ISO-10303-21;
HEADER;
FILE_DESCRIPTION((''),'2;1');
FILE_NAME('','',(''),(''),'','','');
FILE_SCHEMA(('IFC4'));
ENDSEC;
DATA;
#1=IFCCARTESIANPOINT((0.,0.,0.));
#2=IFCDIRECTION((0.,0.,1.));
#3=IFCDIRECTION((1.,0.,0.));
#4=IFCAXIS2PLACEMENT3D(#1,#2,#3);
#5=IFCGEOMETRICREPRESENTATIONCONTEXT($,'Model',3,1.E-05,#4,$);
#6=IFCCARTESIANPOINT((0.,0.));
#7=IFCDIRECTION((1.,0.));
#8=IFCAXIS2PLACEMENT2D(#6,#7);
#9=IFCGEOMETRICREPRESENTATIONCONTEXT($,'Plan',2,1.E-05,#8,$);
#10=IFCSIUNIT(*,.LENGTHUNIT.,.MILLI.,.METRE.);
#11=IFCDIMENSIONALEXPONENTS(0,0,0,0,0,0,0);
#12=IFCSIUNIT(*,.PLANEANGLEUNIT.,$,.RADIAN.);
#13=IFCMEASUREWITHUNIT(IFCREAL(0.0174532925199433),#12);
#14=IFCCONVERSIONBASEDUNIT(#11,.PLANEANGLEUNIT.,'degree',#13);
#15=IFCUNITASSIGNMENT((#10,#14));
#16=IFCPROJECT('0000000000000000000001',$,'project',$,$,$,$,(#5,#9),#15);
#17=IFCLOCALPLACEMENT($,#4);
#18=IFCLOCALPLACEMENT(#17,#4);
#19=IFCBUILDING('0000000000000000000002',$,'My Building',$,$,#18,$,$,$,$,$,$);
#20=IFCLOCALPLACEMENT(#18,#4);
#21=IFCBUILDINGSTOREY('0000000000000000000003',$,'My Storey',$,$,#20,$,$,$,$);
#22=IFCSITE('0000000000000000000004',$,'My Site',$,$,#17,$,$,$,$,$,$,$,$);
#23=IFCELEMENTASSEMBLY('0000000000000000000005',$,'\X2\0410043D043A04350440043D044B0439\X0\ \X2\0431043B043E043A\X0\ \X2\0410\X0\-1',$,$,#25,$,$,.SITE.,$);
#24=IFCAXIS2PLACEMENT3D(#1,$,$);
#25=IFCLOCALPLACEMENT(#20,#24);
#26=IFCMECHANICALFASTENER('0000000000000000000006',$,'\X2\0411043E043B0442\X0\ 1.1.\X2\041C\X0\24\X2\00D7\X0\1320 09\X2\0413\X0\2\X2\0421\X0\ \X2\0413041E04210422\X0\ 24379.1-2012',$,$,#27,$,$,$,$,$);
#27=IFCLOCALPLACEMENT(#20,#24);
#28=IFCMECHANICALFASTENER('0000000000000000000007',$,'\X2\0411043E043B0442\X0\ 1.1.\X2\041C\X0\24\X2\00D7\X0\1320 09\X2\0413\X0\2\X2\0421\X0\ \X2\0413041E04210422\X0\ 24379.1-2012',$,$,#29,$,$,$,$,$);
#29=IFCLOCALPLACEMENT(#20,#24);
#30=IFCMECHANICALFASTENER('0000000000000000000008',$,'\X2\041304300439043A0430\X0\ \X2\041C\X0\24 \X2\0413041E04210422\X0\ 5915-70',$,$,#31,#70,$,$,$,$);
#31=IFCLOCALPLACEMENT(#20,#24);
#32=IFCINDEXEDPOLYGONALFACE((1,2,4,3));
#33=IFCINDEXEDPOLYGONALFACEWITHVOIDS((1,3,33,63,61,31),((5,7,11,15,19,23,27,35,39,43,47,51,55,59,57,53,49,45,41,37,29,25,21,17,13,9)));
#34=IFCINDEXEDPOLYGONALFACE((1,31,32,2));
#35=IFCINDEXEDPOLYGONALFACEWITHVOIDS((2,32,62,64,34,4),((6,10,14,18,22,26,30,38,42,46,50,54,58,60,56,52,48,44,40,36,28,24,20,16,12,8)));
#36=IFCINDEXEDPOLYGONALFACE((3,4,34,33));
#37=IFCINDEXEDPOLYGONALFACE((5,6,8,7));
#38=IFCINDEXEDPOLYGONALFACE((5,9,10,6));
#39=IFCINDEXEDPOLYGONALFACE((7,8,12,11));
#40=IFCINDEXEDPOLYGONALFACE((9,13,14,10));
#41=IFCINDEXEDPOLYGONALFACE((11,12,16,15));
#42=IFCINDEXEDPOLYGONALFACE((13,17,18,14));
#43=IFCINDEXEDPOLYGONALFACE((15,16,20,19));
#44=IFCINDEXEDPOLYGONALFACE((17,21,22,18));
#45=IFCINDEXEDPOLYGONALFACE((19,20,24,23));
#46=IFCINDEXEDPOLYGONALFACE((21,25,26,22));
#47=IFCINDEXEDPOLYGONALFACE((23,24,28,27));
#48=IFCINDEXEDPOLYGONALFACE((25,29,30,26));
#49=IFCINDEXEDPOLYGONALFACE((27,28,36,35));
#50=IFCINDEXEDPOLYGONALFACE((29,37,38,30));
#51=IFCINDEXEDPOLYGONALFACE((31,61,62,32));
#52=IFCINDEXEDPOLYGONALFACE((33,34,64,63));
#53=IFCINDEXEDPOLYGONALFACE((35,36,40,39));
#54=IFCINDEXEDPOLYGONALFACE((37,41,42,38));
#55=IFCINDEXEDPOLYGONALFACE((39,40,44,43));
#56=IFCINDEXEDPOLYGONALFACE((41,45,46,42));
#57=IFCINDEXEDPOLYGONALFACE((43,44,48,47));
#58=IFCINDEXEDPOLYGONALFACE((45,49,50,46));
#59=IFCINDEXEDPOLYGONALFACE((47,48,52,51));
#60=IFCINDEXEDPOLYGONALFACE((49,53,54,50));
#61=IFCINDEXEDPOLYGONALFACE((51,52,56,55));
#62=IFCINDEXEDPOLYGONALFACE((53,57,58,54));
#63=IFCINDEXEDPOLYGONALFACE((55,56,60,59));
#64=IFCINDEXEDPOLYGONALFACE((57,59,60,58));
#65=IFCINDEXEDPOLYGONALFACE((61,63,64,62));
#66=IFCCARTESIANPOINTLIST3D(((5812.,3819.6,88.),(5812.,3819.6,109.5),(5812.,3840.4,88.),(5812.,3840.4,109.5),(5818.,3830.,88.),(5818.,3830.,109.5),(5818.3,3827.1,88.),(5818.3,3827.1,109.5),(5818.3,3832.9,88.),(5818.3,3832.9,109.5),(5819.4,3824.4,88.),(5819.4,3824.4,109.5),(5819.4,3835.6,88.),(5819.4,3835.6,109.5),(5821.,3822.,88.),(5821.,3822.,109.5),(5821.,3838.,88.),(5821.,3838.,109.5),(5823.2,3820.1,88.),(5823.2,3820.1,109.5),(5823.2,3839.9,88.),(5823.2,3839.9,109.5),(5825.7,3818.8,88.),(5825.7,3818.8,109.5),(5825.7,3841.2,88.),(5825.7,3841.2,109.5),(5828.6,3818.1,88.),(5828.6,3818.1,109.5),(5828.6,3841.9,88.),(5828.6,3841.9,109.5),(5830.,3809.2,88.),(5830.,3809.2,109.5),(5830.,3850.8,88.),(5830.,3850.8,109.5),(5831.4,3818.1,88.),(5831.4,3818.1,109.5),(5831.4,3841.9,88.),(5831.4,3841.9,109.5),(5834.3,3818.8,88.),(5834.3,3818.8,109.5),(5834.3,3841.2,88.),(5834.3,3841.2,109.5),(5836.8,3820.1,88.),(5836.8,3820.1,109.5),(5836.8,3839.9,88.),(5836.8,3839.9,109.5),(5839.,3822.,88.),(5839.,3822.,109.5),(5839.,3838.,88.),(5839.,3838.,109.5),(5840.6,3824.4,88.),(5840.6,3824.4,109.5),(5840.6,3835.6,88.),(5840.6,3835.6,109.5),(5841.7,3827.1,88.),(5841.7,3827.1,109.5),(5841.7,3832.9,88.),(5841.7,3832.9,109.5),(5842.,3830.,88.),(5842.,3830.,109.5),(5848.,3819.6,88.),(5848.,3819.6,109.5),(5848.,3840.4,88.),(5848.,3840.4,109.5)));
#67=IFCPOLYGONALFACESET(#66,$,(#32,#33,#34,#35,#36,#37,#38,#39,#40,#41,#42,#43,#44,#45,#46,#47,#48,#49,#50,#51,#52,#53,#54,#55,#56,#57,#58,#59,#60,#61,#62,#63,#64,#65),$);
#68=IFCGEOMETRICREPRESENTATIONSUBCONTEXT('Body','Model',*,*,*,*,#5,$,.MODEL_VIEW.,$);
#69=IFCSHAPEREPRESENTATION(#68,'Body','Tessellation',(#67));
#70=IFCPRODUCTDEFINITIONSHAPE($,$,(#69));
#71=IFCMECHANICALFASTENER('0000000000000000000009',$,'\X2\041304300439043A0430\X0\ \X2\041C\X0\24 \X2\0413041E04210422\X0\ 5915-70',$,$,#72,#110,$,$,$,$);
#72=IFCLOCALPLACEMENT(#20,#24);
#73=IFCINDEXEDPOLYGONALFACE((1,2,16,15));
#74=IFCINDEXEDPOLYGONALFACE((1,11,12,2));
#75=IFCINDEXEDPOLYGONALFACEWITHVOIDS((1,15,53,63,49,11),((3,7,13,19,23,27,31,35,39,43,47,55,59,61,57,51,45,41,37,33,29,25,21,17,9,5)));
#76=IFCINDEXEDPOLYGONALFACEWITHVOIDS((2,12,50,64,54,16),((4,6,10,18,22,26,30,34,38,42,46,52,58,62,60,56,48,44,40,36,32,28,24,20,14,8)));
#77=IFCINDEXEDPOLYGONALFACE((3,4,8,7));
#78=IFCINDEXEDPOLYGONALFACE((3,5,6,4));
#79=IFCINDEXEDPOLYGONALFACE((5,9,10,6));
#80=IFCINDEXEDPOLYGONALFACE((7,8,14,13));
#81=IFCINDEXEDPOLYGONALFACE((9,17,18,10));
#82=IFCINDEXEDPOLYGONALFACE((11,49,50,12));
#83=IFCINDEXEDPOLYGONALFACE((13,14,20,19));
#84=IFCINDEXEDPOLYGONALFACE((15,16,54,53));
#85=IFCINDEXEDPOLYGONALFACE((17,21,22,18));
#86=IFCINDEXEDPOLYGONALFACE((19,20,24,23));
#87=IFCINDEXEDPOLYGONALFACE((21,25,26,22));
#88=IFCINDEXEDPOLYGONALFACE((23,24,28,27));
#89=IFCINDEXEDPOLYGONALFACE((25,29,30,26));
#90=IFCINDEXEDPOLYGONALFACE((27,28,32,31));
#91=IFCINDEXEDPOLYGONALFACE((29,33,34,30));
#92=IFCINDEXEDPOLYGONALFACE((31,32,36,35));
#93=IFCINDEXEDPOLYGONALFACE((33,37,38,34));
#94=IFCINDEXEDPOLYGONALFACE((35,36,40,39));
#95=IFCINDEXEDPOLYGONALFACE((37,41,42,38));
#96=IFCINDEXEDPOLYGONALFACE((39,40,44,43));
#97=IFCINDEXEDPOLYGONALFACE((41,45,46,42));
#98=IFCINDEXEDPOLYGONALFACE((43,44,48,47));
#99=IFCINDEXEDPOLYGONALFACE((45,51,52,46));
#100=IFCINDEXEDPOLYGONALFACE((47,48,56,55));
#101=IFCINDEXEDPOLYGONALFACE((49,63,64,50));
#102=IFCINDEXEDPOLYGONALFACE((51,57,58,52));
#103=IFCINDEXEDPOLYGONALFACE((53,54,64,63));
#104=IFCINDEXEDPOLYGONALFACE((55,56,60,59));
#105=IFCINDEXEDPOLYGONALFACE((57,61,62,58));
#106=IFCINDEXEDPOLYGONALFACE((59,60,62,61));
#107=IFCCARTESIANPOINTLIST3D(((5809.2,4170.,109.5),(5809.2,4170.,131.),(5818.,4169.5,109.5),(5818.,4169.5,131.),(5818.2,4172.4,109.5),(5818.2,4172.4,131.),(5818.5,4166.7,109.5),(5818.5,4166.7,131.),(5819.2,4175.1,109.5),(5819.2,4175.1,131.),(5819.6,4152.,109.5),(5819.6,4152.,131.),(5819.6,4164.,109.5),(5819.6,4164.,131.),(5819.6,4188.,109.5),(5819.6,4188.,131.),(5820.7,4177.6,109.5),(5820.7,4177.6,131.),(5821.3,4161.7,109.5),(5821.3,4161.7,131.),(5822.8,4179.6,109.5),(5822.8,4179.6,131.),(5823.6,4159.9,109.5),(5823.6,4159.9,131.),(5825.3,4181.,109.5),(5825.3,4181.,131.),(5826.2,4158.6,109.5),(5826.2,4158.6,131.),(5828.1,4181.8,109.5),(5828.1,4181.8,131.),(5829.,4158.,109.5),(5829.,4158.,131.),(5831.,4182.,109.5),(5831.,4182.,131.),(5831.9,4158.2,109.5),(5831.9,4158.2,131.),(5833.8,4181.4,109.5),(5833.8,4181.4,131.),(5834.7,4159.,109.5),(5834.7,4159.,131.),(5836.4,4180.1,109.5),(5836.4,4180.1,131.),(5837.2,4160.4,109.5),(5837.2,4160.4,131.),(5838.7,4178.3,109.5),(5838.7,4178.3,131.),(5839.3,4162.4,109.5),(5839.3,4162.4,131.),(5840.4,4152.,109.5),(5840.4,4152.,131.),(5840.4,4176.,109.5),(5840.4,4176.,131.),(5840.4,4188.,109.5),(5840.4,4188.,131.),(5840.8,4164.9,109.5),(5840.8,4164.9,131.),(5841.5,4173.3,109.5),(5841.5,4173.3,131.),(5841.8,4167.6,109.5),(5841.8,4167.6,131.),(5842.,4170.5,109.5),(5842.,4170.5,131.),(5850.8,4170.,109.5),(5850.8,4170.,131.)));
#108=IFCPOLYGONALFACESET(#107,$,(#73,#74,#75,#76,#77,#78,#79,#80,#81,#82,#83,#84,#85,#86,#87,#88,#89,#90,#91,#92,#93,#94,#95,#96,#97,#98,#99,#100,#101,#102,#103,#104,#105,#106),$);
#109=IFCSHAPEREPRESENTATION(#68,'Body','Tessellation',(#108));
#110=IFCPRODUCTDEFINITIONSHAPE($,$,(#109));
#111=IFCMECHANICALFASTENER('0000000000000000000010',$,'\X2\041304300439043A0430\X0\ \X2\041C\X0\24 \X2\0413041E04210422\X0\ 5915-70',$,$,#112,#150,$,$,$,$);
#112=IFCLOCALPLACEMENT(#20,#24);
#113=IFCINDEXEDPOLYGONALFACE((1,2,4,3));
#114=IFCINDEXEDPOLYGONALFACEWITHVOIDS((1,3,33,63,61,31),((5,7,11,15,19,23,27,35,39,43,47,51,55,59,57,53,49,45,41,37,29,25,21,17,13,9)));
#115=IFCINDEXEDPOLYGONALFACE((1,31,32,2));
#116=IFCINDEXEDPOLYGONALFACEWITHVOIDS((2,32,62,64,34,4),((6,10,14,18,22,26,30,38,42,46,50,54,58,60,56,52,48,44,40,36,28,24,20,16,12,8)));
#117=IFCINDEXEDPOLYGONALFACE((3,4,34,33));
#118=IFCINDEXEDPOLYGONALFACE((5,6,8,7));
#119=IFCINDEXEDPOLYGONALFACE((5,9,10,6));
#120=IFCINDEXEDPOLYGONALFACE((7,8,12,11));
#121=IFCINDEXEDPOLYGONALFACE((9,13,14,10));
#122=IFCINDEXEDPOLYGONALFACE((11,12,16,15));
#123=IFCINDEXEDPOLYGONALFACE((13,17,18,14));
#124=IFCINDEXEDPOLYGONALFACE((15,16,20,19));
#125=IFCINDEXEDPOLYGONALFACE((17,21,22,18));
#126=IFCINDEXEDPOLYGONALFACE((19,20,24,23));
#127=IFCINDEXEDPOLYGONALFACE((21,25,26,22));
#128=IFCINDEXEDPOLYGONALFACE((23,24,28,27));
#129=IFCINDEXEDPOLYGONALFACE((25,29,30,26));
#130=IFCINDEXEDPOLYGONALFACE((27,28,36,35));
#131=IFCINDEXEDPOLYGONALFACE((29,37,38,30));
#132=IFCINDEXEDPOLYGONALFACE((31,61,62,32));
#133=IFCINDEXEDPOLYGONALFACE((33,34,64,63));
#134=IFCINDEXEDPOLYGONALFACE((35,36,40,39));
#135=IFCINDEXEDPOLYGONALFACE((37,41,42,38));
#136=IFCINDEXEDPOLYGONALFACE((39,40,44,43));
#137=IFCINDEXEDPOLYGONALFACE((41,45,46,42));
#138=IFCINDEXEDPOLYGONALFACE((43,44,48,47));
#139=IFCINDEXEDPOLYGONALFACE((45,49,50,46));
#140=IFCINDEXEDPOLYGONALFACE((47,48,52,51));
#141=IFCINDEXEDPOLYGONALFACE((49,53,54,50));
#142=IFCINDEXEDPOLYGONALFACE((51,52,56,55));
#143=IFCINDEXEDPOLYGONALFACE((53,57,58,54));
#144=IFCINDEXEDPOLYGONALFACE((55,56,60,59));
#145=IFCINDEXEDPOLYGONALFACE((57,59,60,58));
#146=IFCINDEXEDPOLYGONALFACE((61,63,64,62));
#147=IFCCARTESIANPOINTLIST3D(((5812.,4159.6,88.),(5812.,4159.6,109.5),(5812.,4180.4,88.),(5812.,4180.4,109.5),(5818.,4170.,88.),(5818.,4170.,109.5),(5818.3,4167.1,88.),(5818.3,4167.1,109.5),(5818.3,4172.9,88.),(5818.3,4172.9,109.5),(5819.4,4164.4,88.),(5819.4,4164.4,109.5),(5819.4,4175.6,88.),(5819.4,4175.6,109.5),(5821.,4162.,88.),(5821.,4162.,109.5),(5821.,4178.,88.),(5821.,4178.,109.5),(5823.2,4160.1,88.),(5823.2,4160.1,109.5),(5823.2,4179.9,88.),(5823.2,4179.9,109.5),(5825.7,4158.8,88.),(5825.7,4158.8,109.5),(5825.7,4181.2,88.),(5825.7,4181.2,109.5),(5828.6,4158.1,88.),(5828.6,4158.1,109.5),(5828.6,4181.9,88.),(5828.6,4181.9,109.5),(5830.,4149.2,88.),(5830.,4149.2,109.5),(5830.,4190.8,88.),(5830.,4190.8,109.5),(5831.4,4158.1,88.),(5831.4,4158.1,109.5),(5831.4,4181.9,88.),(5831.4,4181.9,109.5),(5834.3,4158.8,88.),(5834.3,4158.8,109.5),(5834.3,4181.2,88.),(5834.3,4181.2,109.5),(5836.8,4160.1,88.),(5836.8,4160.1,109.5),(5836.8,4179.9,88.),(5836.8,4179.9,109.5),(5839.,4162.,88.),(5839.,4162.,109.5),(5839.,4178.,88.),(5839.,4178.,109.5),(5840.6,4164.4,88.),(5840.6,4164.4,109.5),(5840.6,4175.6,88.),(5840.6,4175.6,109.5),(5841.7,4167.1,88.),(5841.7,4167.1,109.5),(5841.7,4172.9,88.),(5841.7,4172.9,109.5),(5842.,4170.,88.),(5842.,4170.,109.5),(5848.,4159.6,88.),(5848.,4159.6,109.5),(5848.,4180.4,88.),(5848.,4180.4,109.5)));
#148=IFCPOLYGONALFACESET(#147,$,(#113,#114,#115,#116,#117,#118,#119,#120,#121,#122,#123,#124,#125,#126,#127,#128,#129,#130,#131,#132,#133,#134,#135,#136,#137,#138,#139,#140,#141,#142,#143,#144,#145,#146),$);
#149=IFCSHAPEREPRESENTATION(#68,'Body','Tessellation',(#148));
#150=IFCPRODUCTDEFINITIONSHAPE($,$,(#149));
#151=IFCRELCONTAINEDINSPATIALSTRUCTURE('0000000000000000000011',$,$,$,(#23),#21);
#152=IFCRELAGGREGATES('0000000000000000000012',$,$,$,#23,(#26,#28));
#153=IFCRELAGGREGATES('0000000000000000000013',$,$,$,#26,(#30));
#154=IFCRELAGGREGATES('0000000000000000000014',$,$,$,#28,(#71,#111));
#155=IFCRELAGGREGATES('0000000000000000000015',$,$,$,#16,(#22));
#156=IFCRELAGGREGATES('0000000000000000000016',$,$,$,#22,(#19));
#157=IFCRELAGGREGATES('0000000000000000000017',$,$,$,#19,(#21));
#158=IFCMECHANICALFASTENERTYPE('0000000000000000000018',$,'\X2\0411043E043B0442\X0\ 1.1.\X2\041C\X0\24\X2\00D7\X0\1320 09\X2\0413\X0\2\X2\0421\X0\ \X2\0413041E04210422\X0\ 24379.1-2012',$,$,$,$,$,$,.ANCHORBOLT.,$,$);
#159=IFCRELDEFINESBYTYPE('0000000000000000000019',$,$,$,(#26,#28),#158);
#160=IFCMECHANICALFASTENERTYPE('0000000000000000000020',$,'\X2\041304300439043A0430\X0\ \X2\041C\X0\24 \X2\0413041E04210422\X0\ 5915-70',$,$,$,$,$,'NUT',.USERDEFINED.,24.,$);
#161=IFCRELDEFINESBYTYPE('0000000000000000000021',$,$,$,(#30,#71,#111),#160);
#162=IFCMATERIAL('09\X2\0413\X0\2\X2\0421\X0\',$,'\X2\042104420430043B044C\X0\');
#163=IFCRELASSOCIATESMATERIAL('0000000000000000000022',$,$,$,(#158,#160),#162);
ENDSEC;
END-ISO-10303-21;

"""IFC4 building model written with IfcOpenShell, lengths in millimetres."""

from ifc_helpers import new_model, entity, si_unit, converted_unit, frame, origin_with_axes, origin_2d_with_axis, place, context, subcontext, project, spatial, polyline, outline, extrude, source, transform, mapped, material, type_object, type_shapes, element, aggregate, save


model = new_model("IFC4")

# Units and contexts
model_context = context("Model", 3, precision=1e-05, world=origin_with_axes())
plan_context = context("Plan", 2, precision=1e-05, world=origin_2d_with_axis())
body_context = subcontext(model_context, "Body", "Model", "MODEL_VIEW")
ifc_project = project(units=[si_unit("LENGTHUNIT", "METRE", prefix="MILLI"), converted_unit("PLANEANGLEUNIT", "degree", entity("IfcReal", 0.0174532925199433), si_unit("PLANEANGLEUNIT", "RADIAN"), dimensions=[0, 0, 0, 0, 0, 0, 0])], contexts=[model_context, plan_context])

# Site, building, storey
site_placement = place(None, origin_with_axes())
site = spatial("IfcSite", under=ifc_project, at=site_placement, Name="My Site")
building_placement = place(site_placement, origin_with_axes())
building = spatial("IfcBuilding", under=site, at=building_placement, Name="My Building")
storey_placement = place(building_placement, origin_with_axes())
storey = spatial("IfcBuildingStorey", under=building, at=storey_placement, Name="My Storey")

# Element assembly, mechanical fasteners
ifc_material_1 = material(Name="09Г2С", Category="Сталь")
mechanical_fastener_type_1 = type_object("IfcMechanicalFastenerType", Name="Болт 1.1.М24×1320 09Г2С ГОСТ 24379.1-2012", PredefinedType="ANCHORBOLT", material=ifc_material_1)
assembly_1_placement = place(storey_placement, frame((6000.0, 4000.0, 0.0), z_axis=(0.0, 0.0, 1.0), x_axis=(1.0, 0.0, 0.0)))
assembly_1 = element("IfcElementAssembly", 1, at=assembly_1_placement, inside=storey, Name="Анкерный блок А-1", AssemblyPlace="SITE")
mechanical_fastener_1_placement = place(assembly_1_placement, frame((-170.0, -170.0, 0.0), z_axis=(0.0, 0.0, 1.0), x_axis=(1.0, 0.0, 0.0)))
mechanical_fastener_1 = element("IfcMechanicalFastener", 2, at=mechanical_fastener_1_placement, type_object=mechanical_fastener_type_1, Name="Болт 1.1.М24×1320 09Г2С ГОСТ 24379.1-2012")
mechanical_fastener_2_placement = place(assembly_1_placement, frame((-170.0, 170.0, 0.0), z_axis=(0.0, 0.0, 1.0), x_axis=(-1.0, 0.0, 0.0)))
mechanical_fastener_2 = element("IfcMechanicalFastener", 3, at=mechanical_fastener_2_placement, type_object=mechanical_fastener_type_1, Name="Болт 1.1.М24×1320 09Г2С ГОСТ 24379.1-2012")
aggregate(assembly_1, [mechanical_fastener_1, mechanical_fastener_2])

# Mechanical fasteners
mechanical_fastener_type_2 = type_object("IfcMechanicalFastenerType", Name="Гайка М24 ГОСТ 5915-70", ElementType="NUT", NominalDiameter=24.0, PredefinedType="USERDEFINED", material=ifc_material_1)
shared_shape_1 = source(origin_with_axes(), body_context, "Body", "SweptSolid", [
    extrude(outline(polyline([(-10.4, -18.0), (10.4, -18.0), (20.8, 0.0), (10.4, 18.0), (-10.4, 18.0), (-20.8, 0.0), (-10.4, -18.0)]), holes=[polyline([(-8.0, 9.0), (-5.6, 10.6), (-2.9, 11.7), (0.0, 12.0), (2.9, 11.7), (5.6, 10.6), (8.0, 9.0), (9.9, 6.8), (11.2, 4.3), (11.9, 1.4), (11.9, -1.4), (11.2, -4.3), (9.9, -6.8), (8.0, -9.0), (5.6, -10.6), (2.9, -11.7), (0.0, -12.0), (-2.9, -11.7), (-5.6, -10.6), (-8.0, -9.0), (-9.9, -6.8), (-11.2, -4.3), (-11.9, -1.4), (-11.9, 1.4), (-11.2, 4.3), (-9.9, 6.8), (-8.0, 9.0)])]), frame((0.0, 0.0, 0.0), z_axis=(0.0, 0.0, 1.0), x_axis=(0.0, 1.0, 0.0)), (0.0, 0.0, 1.0), 21.5),
])
type_shapes(mechanical_fastener_type_2, [shared_shape_1])
mechanical_fastener_3_placement = place(mechanical_fastener_1_placement, frame((0.0, 0.0, 88.0), z_axis=(0.0, 0.0, 1.0), x_axis=(1.0, 0.0, 0.0)))
mechanical_fastener_3 = element("IfcMechanicalFastener", 4, at=mechanical_fastener_3_placement, type_object=mechanical_fastener_type_2, Name="Гайка М24 ГОСТ 5915-70", context=body_context, shape_type="MappedRepresentation", body=[
    mapped(shared_shape_1, transform((0.0, 0.0, 0.0), x_axis=(1.0, 0.0, 0.0), y_axis=(0.0, 1.0, 0.0), z_axis=(0.0, 0.0, 1.0), scale=1.0)),
])
mechanical_fastener_4_placement = place(mechanical_fastener_2_placement, frame((0.0, 0.0, 109.5), z_axis=(0.0, 0.0, 1.0), x_axis=(0.866025, 0.5, 0.0)))
mechanical_fastener_4 = element("IfcMechanicalFastener", 5, at=mechanical_fastener_4_placement, type_object=mechanical_fastener_type_2, Name="Гайка М24 ГОСТ 5915-70", context=body_context, shape_type="MappedRepresentation", body=[
    mapped(shared_shape_1, transform((0.0, 0.0, 0.0), x_axis=(1.0, 0.0, 0.0), y_axis=(0.0, 1.0, 0.0), z_axis=(0.0, 0.0, 1.0), scale=1.0)),
])
mechanical_fastener_5_placement = place(mechanical_fastener_2_placement, frame((0.0, 0.0, 88.0), z_axis=(0.0, 0.0, 1.0), x_axis=(1.0, 0.0, 0.0)))
mechanical_fastener_5 = element("IfcMechanicalFastener", 6, at=mechanical_fastener_5_placement, type_object=mechanical_fastener_type_2, Name="Гайка М24 ГОСТ 5915-70", context=body_context, shape_type="MappedRepresentation", body=[
    mapped(shared_shape_1, transform((0.0, 0.0, 0.0), x_axis=(1.0, 0.0, 0.0), y_axis=(0.0, 1.0, 0.0), z_axis=(0.0, 0.0, 1.0), scale=1.0)),
])
aggregate(mechanical_fastener_1, [mechanical_fastener_3])
aggregate(mechanical_fastener_2, [mechanical_fastener_4, mechanical_fastener_5])

save(model, "model.ifc")
